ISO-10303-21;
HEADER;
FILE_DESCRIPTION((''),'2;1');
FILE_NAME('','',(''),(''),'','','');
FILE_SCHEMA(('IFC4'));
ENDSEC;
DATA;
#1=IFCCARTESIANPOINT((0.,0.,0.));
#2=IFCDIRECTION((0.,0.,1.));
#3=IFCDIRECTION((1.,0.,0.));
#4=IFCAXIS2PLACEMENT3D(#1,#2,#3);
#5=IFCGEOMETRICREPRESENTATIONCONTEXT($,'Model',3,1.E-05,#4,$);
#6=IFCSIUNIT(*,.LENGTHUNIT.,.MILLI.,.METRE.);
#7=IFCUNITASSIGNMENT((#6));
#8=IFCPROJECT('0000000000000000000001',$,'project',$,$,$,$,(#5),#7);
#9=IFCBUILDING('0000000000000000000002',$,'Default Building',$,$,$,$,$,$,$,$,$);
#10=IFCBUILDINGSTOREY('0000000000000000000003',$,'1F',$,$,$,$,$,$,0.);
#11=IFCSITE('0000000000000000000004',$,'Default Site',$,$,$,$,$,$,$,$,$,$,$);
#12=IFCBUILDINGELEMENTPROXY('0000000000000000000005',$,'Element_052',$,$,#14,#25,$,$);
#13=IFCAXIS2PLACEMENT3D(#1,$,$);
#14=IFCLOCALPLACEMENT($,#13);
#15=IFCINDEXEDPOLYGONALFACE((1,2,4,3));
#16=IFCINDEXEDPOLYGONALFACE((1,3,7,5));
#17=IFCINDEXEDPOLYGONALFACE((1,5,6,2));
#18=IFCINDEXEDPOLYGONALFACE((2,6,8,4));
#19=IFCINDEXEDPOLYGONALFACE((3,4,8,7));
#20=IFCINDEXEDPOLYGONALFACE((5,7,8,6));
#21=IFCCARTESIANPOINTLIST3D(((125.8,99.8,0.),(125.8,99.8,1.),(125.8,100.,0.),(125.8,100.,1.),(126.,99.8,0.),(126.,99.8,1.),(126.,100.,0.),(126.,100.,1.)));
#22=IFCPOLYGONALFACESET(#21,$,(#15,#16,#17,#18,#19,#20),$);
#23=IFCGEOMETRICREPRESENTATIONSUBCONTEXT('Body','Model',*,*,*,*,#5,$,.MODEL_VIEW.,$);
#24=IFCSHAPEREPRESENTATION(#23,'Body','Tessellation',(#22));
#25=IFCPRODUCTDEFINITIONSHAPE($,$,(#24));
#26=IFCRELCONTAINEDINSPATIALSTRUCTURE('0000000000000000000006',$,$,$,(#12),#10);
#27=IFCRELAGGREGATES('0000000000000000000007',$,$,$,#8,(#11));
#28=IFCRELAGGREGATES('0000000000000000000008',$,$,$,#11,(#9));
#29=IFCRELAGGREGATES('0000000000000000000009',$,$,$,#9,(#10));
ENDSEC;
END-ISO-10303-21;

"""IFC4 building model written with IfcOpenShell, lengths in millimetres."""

from ifc_helpers import new_model, si_unit, frame, origin, origin_with_axes, place, context, subcontext, project, spatial, polyline, outline, extrude, element, save


model = new_model("IFC4")

# Units and contexts
model_context = context("Model", 3, precision=1e-05, world=origin_with_axes())
body_context = subcontext(model_context, "Body", "Model", "MODEL_VIEW")
ifc_project = project(units=[si_unit("LENGTHUNIT", "METRE", prefix="MILLI")], contexts=[model_context])

# Site, building, storey
site = spatial("IfcSite", under=ifc_project, Name="Default Site")
building = spatial("IfcBuilding", under=site, Name="Default Building")
storey = spatial("IfcBuildingStorey", under=building, Name="1F", Elevation=0.0)

# Building element proxy
proxy_1_placement = place(None, frame((125.9, 99.9, 0.0), z_axis=(0.0, 0.0, 1.0), x_axis=(1.0, 0.0, 0.0)))
element("IfcBuildingElementProxy", 1, at=proxy_1_placement, inside=storey, Name="Element_052", context=body_context, shape_type="SweptSolid", body=[
    extrude(outline(polyline([(0.1, -0.1), (-0.1, -0.1), (-0.1, 0.1), (0.1, 0.1), (0.1, -0.1)])), origin(), (0.0, 0.0, 1.0), 1.0),
])

save(model, "model.ifc")
